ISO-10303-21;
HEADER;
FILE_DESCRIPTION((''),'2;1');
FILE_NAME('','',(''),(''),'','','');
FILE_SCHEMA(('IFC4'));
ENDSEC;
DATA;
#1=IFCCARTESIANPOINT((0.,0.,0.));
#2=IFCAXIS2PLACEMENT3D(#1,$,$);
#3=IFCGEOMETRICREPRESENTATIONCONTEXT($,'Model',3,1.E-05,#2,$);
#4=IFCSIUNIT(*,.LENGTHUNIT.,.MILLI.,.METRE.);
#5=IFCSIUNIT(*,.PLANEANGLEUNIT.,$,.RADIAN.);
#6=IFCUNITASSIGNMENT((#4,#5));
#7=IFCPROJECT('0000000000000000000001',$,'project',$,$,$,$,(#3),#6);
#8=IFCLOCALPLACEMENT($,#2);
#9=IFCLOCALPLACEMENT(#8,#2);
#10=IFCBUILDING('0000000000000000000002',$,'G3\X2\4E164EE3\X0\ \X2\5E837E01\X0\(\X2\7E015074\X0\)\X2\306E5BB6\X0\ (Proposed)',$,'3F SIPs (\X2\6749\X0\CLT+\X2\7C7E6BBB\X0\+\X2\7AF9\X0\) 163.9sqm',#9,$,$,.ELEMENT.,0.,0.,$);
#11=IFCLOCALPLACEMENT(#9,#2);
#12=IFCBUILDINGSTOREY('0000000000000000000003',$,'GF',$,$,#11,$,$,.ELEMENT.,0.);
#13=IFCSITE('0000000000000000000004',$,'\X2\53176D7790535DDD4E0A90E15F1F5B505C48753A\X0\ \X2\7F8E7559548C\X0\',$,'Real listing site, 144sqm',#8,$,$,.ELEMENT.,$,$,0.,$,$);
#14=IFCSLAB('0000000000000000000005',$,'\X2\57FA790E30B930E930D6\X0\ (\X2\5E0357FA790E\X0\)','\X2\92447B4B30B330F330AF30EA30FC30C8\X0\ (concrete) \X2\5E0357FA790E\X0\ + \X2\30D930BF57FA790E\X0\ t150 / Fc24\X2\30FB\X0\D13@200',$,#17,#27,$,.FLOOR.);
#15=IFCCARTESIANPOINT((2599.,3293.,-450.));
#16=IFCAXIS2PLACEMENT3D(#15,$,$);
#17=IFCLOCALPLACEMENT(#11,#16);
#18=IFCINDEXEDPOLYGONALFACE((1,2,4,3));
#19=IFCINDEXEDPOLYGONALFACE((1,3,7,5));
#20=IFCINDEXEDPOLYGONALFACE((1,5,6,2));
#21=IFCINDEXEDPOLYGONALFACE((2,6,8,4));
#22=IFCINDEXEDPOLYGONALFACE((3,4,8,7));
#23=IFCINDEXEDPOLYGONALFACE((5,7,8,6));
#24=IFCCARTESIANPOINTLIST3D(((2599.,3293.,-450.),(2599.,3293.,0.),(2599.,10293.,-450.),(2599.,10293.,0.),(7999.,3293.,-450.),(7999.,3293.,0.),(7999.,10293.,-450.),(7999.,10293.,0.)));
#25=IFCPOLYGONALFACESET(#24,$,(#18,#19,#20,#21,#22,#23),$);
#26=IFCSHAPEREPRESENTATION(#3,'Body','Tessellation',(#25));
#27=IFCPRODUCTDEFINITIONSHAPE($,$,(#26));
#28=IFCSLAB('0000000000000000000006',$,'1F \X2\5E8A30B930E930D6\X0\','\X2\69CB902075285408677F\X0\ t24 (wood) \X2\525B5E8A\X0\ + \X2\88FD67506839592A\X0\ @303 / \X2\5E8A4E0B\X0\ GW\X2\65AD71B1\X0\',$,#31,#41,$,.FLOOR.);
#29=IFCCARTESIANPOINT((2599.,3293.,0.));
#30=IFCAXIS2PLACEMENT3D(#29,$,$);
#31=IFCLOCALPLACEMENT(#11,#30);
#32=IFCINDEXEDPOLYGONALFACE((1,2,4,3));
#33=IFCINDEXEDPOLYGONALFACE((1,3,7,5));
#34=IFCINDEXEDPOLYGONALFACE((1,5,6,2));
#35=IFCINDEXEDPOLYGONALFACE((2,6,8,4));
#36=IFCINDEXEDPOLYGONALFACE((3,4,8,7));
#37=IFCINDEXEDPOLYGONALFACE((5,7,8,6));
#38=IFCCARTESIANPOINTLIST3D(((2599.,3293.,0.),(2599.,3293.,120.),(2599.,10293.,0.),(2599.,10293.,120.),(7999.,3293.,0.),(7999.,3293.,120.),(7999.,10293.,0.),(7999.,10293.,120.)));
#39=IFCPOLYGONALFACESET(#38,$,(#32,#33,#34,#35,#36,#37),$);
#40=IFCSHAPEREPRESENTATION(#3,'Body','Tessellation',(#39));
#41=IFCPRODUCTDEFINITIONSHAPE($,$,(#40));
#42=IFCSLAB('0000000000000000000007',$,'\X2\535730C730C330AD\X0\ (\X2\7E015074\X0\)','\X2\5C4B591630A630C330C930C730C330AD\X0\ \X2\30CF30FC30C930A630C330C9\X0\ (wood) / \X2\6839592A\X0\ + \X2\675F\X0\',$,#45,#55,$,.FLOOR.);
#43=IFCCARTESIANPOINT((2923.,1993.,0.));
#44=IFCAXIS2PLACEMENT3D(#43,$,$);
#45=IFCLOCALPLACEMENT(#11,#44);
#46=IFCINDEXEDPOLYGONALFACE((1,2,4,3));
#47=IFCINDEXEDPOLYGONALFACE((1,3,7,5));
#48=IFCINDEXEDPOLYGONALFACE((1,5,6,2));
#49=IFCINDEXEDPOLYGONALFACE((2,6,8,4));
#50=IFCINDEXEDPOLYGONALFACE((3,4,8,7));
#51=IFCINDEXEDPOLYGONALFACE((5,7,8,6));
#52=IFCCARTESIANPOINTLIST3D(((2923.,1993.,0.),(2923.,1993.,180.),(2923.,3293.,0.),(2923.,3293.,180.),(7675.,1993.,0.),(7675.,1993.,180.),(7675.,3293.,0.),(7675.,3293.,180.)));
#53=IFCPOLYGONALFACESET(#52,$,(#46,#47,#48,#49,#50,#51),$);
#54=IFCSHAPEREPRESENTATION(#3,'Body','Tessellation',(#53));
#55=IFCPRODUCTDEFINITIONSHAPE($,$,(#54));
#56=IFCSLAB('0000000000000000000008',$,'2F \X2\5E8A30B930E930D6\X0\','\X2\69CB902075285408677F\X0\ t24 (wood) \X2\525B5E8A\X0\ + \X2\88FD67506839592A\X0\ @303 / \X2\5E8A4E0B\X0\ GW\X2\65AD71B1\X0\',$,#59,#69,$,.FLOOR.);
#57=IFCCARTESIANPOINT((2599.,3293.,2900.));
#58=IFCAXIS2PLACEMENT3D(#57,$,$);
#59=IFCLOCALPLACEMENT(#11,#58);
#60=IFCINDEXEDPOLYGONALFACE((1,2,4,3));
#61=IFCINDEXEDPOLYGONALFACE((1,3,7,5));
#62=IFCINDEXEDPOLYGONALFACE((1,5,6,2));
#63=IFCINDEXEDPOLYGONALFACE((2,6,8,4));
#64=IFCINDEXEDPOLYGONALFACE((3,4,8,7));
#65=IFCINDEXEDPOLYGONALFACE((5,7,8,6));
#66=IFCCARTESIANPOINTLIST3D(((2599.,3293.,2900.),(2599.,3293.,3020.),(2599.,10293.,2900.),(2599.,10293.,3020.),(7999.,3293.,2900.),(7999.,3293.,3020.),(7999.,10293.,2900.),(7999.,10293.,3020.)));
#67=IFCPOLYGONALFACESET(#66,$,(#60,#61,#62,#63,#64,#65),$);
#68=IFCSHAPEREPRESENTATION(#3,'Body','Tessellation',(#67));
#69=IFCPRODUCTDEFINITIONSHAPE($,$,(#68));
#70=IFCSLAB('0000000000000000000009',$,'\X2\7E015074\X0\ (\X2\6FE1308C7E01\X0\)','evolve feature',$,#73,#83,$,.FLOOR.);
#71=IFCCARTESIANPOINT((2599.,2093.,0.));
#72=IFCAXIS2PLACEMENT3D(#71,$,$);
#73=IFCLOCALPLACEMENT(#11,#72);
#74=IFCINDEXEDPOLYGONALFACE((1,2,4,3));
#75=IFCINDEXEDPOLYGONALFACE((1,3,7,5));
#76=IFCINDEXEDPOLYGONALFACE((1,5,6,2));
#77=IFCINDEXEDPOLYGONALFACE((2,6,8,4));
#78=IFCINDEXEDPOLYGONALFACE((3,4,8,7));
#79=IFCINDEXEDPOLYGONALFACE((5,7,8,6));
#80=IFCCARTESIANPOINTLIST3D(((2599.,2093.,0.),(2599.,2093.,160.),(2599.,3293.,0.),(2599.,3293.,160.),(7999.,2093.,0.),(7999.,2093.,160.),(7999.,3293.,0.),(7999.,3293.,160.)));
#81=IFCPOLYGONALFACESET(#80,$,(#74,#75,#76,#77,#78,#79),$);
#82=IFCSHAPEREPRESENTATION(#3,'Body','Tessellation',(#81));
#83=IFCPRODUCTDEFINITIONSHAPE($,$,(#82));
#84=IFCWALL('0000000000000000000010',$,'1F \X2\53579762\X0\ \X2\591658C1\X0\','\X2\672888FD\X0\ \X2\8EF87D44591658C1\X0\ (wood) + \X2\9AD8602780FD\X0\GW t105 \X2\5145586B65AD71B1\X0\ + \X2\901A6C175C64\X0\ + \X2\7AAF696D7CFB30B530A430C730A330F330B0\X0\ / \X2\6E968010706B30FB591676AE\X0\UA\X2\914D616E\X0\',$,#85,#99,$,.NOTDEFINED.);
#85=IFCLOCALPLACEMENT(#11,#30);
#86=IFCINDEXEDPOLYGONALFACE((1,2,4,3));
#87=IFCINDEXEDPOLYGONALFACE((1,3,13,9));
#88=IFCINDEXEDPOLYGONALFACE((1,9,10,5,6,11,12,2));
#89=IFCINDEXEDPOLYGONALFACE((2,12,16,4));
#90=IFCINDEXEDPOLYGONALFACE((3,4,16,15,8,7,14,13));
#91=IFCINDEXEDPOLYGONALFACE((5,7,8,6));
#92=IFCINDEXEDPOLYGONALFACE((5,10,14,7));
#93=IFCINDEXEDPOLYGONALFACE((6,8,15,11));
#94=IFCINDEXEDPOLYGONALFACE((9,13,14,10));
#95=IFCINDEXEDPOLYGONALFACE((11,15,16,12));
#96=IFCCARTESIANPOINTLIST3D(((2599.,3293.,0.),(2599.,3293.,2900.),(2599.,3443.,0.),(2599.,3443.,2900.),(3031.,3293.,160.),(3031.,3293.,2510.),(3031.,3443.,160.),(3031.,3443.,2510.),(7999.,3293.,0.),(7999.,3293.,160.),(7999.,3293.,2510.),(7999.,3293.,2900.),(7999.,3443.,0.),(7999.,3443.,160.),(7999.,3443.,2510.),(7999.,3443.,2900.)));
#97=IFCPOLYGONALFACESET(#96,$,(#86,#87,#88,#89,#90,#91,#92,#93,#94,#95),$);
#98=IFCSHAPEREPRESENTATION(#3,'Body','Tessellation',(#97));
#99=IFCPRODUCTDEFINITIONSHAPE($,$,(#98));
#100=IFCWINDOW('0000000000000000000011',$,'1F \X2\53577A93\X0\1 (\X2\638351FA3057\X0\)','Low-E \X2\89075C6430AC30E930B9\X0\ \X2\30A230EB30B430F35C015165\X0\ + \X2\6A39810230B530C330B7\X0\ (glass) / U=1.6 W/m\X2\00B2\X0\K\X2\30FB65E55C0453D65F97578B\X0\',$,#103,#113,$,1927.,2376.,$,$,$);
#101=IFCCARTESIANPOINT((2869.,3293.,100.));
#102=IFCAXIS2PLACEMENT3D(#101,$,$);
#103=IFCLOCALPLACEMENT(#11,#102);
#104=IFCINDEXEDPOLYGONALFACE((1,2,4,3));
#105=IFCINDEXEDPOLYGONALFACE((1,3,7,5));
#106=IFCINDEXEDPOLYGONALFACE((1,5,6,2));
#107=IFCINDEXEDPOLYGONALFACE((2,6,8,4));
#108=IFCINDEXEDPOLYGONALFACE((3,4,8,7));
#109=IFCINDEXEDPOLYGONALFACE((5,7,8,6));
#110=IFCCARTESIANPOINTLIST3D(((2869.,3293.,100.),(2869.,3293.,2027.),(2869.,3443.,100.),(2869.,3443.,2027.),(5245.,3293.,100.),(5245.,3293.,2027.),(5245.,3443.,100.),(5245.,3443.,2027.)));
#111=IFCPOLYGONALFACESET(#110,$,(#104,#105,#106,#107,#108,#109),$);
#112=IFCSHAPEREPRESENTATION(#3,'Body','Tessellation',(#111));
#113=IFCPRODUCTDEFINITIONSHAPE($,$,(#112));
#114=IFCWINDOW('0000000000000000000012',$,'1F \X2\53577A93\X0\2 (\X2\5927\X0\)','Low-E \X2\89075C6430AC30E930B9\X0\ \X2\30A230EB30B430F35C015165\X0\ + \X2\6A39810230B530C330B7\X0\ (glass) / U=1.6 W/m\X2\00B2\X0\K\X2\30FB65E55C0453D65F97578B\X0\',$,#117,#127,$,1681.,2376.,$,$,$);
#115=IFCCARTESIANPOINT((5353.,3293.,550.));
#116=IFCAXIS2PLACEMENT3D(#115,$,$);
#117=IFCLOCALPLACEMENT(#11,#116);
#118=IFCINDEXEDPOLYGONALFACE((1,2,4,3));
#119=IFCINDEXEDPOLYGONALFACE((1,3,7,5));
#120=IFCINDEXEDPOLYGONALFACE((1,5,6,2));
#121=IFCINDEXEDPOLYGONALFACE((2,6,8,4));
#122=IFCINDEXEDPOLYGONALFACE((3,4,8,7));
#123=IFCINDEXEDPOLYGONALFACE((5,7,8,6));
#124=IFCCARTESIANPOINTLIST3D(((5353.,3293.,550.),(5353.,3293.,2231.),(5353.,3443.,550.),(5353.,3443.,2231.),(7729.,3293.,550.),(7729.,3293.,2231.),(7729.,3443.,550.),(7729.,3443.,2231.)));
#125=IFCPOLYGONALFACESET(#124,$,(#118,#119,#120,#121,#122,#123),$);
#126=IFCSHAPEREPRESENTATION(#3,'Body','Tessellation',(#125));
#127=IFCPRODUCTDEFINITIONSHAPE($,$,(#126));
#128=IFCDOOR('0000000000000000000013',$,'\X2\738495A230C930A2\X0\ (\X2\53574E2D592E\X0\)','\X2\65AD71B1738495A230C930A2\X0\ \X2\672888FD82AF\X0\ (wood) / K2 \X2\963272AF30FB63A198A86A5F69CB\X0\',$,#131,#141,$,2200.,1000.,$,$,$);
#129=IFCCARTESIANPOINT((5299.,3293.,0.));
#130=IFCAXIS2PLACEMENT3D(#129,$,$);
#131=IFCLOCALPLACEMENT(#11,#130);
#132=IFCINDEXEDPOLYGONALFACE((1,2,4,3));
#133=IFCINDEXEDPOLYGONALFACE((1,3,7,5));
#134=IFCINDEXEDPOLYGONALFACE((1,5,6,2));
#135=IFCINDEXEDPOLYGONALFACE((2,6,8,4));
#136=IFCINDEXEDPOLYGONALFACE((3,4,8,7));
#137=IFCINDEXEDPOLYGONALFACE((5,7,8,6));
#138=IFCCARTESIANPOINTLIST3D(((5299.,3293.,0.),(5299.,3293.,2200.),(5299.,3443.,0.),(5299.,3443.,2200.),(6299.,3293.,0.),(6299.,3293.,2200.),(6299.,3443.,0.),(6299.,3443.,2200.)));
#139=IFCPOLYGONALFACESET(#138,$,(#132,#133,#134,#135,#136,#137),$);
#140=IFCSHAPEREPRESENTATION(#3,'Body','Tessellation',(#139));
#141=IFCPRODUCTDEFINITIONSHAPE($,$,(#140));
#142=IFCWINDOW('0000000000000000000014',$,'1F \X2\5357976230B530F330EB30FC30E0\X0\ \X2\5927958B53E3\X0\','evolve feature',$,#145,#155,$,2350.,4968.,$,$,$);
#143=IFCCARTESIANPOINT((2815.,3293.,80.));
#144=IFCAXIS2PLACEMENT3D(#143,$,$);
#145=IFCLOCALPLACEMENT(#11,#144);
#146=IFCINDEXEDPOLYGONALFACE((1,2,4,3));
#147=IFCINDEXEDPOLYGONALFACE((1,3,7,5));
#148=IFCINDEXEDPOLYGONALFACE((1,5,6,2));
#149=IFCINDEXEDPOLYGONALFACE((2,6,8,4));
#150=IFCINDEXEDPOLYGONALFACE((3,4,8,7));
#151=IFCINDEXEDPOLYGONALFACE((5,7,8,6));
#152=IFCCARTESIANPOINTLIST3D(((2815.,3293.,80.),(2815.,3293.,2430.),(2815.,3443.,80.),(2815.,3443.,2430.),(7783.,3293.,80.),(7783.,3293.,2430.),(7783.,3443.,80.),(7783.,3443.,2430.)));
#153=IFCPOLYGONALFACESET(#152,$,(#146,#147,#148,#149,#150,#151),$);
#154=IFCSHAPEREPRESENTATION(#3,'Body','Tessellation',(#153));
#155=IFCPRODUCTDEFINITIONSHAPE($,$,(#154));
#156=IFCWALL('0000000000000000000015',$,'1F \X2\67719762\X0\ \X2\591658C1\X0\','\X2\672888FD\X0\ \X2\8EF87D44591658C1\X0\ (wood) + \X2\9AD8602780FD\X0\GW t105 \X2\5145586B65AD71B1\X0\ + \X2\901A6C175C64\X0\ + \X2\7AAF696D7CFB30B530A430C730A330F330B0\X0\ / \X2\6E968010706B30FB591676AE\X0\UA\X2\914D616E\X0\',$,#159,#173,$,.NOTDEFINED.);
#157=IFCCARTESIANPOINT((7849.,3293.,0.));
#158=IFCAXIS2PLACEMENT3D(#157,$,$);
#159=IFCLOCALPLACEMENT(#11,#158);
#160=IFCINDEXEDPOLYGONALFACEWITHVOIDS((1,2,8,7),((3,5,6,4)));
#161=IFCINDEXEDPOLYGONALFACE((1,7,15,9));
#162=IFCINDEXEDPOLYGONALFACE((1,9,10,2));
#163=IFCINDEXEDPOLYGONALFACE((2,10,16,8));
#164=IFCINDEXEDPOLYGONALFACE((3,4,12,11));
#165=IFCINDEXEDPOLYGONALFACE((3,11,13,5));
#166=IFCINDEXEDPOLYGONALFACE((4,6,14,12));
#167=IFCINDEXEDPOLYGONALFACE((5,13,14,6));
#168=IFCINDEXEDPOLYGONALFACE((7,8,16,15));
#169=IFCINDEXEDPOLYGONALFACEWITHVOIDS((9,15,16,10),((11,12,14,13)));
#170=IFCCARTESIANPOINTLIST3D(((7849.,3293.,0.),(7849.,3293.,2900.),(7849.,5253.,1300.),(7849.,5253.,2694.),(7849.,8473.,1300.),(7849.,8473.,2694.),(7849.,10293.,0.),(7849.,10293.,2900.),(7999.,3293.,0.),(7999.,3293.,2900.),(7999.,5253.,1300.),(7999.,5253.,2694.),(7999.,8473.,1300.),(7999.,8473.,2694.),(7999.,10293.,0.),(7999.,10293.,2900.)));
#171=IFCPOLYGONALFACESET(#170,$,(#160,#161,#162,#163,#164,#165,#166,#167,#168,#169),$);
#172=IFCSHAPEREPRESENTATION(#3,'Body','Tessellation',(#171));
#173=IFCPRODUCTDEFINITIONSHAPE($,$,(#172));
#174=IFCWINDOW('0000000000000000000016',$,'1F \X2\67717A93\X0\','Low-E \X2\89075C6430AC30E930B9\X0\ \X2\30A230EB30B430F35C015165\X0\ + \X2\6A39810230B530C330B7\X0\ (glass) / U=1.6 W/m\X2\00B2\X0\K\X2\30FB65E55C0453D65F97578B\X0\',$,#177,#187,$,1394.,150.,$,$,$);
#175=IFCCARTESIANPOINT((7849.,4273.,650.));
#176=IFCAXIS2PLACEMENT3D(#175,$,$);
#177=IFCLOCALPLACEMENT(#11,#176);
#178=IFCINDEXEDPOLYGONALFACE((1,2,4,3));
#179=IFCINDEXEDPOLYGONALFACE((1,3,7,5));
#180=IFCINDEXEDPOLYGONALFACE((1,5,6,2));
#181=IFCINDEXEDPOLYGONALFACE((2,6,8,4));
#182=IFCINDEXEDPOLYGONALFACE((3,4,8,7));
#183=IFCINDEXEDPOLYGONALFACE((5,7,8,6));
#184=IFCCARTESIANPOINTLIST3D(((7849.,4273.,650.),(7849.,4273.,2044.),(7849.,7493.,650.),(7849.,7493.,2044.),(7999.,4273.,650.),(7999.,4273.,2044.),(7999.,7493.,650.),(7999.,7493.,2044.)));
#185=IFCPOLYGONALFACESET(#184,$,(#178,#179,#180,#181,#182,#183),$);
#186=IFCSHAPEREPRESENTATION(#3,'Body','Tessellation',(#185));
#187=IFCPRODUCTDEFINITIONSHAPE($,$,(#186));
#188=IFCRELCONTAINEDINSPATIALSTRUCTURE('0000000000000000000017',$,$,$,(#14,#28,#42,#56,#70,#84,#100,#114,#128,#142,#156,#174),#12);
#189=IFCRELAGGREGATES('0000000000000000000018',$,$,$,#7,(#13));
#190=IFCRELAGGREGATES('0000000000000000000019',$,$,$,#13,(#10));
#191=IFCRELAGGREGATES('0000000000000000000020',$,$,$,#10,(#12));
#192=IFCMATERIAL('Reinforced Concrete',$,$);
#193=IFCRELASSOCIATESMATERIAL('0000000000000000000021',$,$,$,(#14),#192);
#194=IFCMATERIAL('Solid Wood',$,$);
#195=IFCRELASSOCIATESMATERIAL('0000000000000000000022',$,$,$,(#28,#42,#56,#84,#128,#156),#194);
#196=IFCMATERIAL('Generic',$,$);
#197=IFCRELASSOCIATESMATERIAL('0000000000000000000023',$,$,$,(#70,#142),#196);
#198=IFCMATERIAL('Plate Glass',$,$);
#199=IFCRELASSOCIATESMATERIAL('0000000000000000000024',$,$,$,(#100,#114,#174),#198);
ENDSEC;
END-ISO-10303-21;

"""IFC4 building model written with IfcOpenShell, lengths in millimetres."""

from ifc_helpers import new_model, si_unit, frame, frame_2d, origin, place, context, project, spatial, rectangle, extrude, material, element, fill, save


model = new_model("IFC4")

# Units and contexts
model_context = context("Model", 3, precision=1e-05, world=origin())
ifc_project = project(units=[si_unit("LENGTHUNIT", "METRE", prefix="MILLI"), si_unit("PLANEANGLEUNIT", "RADIAN")], contexts=[model_context])

# Site, building, storey
site_placement = place(None, origin())
site = spatial("IfcSite", under=ifc_project, at=site_placement, Name="北海道川上郡弟子屈町 美留和", ObjectType="Real listing site, 144sqm", CompositionType="ELEMENT", RefElevation=0.0)
building_placement = place(site_placement, origin())
building = spatial("IfcBuilding", under=site, at=building_placement, Name="G3世代 広縁(縁側)の家 (Proposed)", ObjectType="3F SIPs (杉CLT+籾殻+竹) 163.9sqm", CompositionType="ELEMENT", ElevationOfRefHeight=0.0, ElevationOfTerrain=0.0)
storey_placement = place(building_placement, origin())
storey = spatial("IfcBuildingStorey", under=building, at=storey_placement, Name="GF", CompositionType="ELEMENT", Elevation=0.0)

# Slabs
ifc_material_1 = material(Name="Reinforced Concrete")
slab_1_placement = place(storey_placement, frame((2599.0, 3293.0, -450.0)))
element("IfcSlab", 1, at=slab_1_placement, inside=storey, material=ifc_material_1, Name="基礎スラブ (布基礎)", Description="鉄筋コンクリート (concrete) 布基礎 + ベタ基礎 t150 / Fc24・D13@200", PredefinedType="FLOOR", context=model_context, shape_type="SweptSolid", body=[
    extrude(rectangle(XDim=5400.0, YDim=7000.0, at=frame_2d((2700.0, 3500.0))), frame((2599.0, 3293.0, -450.0)), (0.0, 0.0, 1.0), 450.0),
])
ifc_material_2 = material(Name="Solid Wood")
slab_2_placement = place(storey_placement, frame((2599.0, 3293.0, 0.0)))
element("IfcSlab", 2, at=slab_2_placement, inside=storey, material=ifc_material_2, Name="1F 床スラブ", Description="構造用合板 t24 (wood) 剛床 + 製材根太 @303 / 床下 GW断熱", PredefinedType="FLOOR", context=model_context, shape_type="SweptSolid", body=[
    extrude(rectangle(XDim=5400.0, YDim=7000.0, at=frame_2d((2700.0, 3500.0))), frame((2599.0, 3293.0, 0.0)), (0.0, 0.0, 1.0), 120.0),
])
slab_3_placement = place(storey_placement, frame((2923.0, 1993.0, 0.0)))
element("IfcSlab", 3, at=slab_3_placement, inside=storey, material=ifc_material_2, Name="南デッキ (縁側)", Description="屋外ウッドデッキ ハードウッド (wood) / 根太 + 束", PredefinedType="FLOOR", context=model_context, shape_type="SweptSolid", body=[
    extrude(rectangle(XDim=4752.0, YDim=1300.0, at=frame_2d((2376.0, 650.0))), frame((2923.0, 1993.0, 0.0)), (0.0, 0.0, 1.0), 180.0),
])
slab_4_placement = place(storey_placement, frame((2599.0, 3293.0, 2900.0)))
element("IfcSlab", 4, at=slab_4_placement, inside=storey, material=ifc_material_2, Name="2F 床スラブ", Description="構造用合板 t24 (wood) 剛床 + 製材根太 @303 / 床下 GW断熱", PredefinedType="FLOOR", context=model_context, shape_type="SweptSolid", body=[
    extrude(rectangle(XDim=5400.0, YDim=7000.0, at=frame_2d((2700.0, 3500.0))), frame((2599.0, 3293.0, 2900.0)), (0.0, 0.0, 1.0), 120.0),
])
ifc_material_3 = material(Name="Generic")
slab_5_placement = place(storey_placement, frame((2599.0, 2093.0, 0.0)))
element("IfcSlab", 5, at=slab_5_placement, inside=storey, material=ifc_material_3, Name="縁側 (濡れ縁)", Description="evolve feature", PredefinedType="FLOOR", context=model_context, shape_type="SweptSolid", body=[
    extrude(rectangle(XDim=5400.0, YDim=1200.0, at=frame_2d((2700.0, 600.0))), frame((2599.0, 2093.0, 0.0)), (0.0, 0.0, 1.0), 160.0),
])

# Wall, openings, windows, door
wall_1_placement = place(storey_placement, frame((2599.0, 3293.0, 0.0)))
wall_1 = element("IfcWall", 6, at=wall_1_placement, inside=storey, material=ifc_material_2, Name="1F 南面 外壁", Description="木製 軸組外壁 (wood) + 高性能GW t105 充填断熱 + 通気層 + 窯業系サイディング / 準耐火・外皮UA配慮", PredefinedType="NOTDEFINED", context=model_context, shape_type="SweptSolid", body=[
    extrude(rectangle(XDim=5400.0, YDim=150.0, at=frame_2d((2700.0, 75.0))), frame((2599.0, 3293.0, 0.0)), (0.0, 0.0, 1.0), 2900.0),
])
opening_1_placement = place(storey_placement, frame((2869.0, 3293.0, 100.0)))
opening_1 = element("IfcOpeningElement", 7, at=opening_1_placement, cuts=wall_1, PredefinedType="NOTDEFINED", context=model_context, shape_type="SweptSolid", body=[
    extrude(rectangle(XDim=2376.0, YDim=150.0, at=frame_2d((1188.0, 75.0))), frame((2869.0, 3293.0, 100.0)), (0.0, 0.0, 1.0), 1927.0),
])
opening_2_placement = place(storey_placement, frame((5353.0, 3293.0, 550.0)))
opening_2 = element("IfcOpeningElement", 8, at=opening_2_placement, cuts=wall_1, PredefinedType="NOTDEFINED", context=model_context, shape_type="SweptSolid", body=[
    extrude(rectangle(XDim=2376.0, YDim=150.0, at=frame_2d((1188.0, 75.0))), frame((5353.0, 3293.0, 550.0)), (0.0, 0.0, 1.0), 1681.0),
])
opening_3_placement = place(storey_placement, frame((5299.0, 3293.0, 0.0)))
opening_3 = element("IfcOpeningElement", 9, at=opening_3_placement, cuts=wall_1, PredefinedType="NOTDEFINED", context=model_context, shape_type="SweptSolid", body=[
    extrude(rectangle(XDim=1000.0, YDim=150.0, at=frame_2d((500.0, 75.0))), frame((5299.0, 3293.0, 0.0)), (0.0, 0.0, 1.0), 2200.0),
])
opening_4_placement = place(storey_placement, frame((2815.0, 3293.0, 80.0)))
opening_4 = element("IfcOpeningElement", 10, at=opening_4_placement, cuts=wall_1, PredefinedType="NOTDEFINED", context=model_context, shape_type="SweptSolid", body=[
    extrude(rectangle(XDim=4968.0, YDim=150.0, at=frame_2d((2484.0, 75.0))), frame((2815.0, 3293.0, 80.0)), (0.0, 0.0, 1.0), 2350.0),
])
ifc_material_4 = material(Name="Plate Glass")
window_1_placement = place(storey_placement, frame((2869.0, 3293.0, 100.0)))
window_1 = element("IfcWindow", 11, at=window_1_placement, inside=storey, material=ifc_material_4, Name="1F 南窓1 (掃出し)", Description="Low-E 複層ガラス アルゴン封入 + 樹脂サッシ (glass) / U=1.6 W/m²K・日射取得型", OverallHeight=1927.0, OverallWidth=2376.0, context=model_context, shape_type="SweptSolid", body=[
    extrude(rectangle(XDim=2376.0, YDim=150.0, at=frame_2d((1188.0, 75.0))), frame((2869.0, 3293.0, 100.0)), (0.0, 0.0, 1.0), 1927.0),
])
fill(opening_1, window_1)
window_2_placement = place(storey_placement, frame((5353.0, 3293.0, 550.0)))
window_2 = element("IfcWindow", 12, at=window_2_placement, inside=storey, material=ifc_material_4, Name="1F 南窓2 (大)", Description="Low-E 複層ガラス アルゴン封入 + 樹脂サッシ (glass) / U=1.6 W/m²K・日射取得型", OverallHeight=1681.0, OverallWidth=2376.0, context=model_context, shape_type="SweptSolid", body=[
    extrude(rectangle(XDim=2376.0, YDim=150.0, at=frame_2d((1188.0, 75.0))), frame((5353.0, 3293.0, 550.0)), (0.0, 0.0, 1.0), 1681.0),
])
fill(opening_2, window_2)
door_placement = place(storey_placement, frame((5299.0, 3293.0, 0.0)))
door = element("IfcDoor", 13, at=door_placement, inside=storey, material=ifc_material_2, Name="玄関ドア (南中央)", Description="断熱玄関ドア 木製芯 (wood) / K2 防犯・採風機構", OverallHeight=2200.0, OverallWidth=1000.0, context=model_context, shape_type="SweptSolid", body=[
    extrude(rectangle(XDim=1000.0, YDim=150.0, at=frame_2d((500.0, 75.0))), frame((5299.0, 3293.0, 0.0)), (0.0, 0.0, 1.0), 2200.0),
])
fill(opening_3, door)
window_3_placement = place(storey_placement, frame((2815.0, 3293.0, 80.0)))
window_3 = element("IfcWindow", 14, at=window_3_placement, inside=storey, material=ifc_material_3, Name="1F 南面サンルーム 大開口", Description="evolve feature", OverallHeight=2350.0, OverallWidth=4968.0, context=model_context, shape_type="SweptSolid", body=[
    extrude(rectangle(XDim=4968.0, YDim=150.0, at=frame_2d((2484.0, 75.0))), frame((2815.0, 3293.0, 80.0)), (0.0, 0.0, 1.0), 2350.0),
])
fill(opening_4, window_3)

# Wall, opening, window
wall_2_placement = place(storey_placement, frame((7849.0, 3293.0, 0.0)))
wall_2 = element("IfcWall", 15, at=wall_2_placement, inside=storey, material=ifc_material_2, Name="1F 東面 外壁", Description="木製 軸組外壁 (wood) + 高性能GW t105 充填断熱 + 通気層 + 窯業系サイディング / 準耐火・外皮UA配慮", PredefinedType="NOTDEFINED", context=model_context, shape_type="SweptSolid", body=[
    extrude(rectangle(XDim=150.0, YDim=7000.0, at=frame_2d((75.0, 3500.0))), frame((7849.0, 3293.0, 0.0)), (0.0, 0.0, 1.0), 2900.0),
])
opening_5_placement = place(storey_placement, frame((7849.0, 4273.0, 650.0)))
opening_5 = element("IfcOpeningElement", 16, at=opening_5_placement, cuts=wall_2, PredefinedType="NOTDEFINED", context=model_context, shape_type="SweptSolid", body=[
    extrude(rectangle(XDim=150.0, YDim=3220.0, at=frame_2d((75.0, 1610.0))), frame((7849.0, 4273.0, 650.0)), (0.0, 0.0, 1.0), 1394.0),
])
window_4_placement = place(storey_placement, frame((7849.0, 4273.0, 650.0)))
window_4 = element("IfcWindow", 17, at=window_4_placement, inside=storey, material=ifc_material_4, Name="1F 東窓", Description="Low-E 複層ガラス アルゴン封入 + 樹脂サッシ (glass) / U=1.6 W/m²K・日射取得型", OverallHeight=1394.0, OverallWidth=150.0, context=model_context, shape_type="SweptSolid", body=[
    extrude(rectangle(XDim=150.0, YDim=3220.0, at=frame_2d((75.0, 1610.0))), frame((7849.0, 4273.0, 650.0)), (0.0, 0.0, 1.0), 1394.0),
])
fill(opening_5, window_4)

save(model, "model.ifc")
